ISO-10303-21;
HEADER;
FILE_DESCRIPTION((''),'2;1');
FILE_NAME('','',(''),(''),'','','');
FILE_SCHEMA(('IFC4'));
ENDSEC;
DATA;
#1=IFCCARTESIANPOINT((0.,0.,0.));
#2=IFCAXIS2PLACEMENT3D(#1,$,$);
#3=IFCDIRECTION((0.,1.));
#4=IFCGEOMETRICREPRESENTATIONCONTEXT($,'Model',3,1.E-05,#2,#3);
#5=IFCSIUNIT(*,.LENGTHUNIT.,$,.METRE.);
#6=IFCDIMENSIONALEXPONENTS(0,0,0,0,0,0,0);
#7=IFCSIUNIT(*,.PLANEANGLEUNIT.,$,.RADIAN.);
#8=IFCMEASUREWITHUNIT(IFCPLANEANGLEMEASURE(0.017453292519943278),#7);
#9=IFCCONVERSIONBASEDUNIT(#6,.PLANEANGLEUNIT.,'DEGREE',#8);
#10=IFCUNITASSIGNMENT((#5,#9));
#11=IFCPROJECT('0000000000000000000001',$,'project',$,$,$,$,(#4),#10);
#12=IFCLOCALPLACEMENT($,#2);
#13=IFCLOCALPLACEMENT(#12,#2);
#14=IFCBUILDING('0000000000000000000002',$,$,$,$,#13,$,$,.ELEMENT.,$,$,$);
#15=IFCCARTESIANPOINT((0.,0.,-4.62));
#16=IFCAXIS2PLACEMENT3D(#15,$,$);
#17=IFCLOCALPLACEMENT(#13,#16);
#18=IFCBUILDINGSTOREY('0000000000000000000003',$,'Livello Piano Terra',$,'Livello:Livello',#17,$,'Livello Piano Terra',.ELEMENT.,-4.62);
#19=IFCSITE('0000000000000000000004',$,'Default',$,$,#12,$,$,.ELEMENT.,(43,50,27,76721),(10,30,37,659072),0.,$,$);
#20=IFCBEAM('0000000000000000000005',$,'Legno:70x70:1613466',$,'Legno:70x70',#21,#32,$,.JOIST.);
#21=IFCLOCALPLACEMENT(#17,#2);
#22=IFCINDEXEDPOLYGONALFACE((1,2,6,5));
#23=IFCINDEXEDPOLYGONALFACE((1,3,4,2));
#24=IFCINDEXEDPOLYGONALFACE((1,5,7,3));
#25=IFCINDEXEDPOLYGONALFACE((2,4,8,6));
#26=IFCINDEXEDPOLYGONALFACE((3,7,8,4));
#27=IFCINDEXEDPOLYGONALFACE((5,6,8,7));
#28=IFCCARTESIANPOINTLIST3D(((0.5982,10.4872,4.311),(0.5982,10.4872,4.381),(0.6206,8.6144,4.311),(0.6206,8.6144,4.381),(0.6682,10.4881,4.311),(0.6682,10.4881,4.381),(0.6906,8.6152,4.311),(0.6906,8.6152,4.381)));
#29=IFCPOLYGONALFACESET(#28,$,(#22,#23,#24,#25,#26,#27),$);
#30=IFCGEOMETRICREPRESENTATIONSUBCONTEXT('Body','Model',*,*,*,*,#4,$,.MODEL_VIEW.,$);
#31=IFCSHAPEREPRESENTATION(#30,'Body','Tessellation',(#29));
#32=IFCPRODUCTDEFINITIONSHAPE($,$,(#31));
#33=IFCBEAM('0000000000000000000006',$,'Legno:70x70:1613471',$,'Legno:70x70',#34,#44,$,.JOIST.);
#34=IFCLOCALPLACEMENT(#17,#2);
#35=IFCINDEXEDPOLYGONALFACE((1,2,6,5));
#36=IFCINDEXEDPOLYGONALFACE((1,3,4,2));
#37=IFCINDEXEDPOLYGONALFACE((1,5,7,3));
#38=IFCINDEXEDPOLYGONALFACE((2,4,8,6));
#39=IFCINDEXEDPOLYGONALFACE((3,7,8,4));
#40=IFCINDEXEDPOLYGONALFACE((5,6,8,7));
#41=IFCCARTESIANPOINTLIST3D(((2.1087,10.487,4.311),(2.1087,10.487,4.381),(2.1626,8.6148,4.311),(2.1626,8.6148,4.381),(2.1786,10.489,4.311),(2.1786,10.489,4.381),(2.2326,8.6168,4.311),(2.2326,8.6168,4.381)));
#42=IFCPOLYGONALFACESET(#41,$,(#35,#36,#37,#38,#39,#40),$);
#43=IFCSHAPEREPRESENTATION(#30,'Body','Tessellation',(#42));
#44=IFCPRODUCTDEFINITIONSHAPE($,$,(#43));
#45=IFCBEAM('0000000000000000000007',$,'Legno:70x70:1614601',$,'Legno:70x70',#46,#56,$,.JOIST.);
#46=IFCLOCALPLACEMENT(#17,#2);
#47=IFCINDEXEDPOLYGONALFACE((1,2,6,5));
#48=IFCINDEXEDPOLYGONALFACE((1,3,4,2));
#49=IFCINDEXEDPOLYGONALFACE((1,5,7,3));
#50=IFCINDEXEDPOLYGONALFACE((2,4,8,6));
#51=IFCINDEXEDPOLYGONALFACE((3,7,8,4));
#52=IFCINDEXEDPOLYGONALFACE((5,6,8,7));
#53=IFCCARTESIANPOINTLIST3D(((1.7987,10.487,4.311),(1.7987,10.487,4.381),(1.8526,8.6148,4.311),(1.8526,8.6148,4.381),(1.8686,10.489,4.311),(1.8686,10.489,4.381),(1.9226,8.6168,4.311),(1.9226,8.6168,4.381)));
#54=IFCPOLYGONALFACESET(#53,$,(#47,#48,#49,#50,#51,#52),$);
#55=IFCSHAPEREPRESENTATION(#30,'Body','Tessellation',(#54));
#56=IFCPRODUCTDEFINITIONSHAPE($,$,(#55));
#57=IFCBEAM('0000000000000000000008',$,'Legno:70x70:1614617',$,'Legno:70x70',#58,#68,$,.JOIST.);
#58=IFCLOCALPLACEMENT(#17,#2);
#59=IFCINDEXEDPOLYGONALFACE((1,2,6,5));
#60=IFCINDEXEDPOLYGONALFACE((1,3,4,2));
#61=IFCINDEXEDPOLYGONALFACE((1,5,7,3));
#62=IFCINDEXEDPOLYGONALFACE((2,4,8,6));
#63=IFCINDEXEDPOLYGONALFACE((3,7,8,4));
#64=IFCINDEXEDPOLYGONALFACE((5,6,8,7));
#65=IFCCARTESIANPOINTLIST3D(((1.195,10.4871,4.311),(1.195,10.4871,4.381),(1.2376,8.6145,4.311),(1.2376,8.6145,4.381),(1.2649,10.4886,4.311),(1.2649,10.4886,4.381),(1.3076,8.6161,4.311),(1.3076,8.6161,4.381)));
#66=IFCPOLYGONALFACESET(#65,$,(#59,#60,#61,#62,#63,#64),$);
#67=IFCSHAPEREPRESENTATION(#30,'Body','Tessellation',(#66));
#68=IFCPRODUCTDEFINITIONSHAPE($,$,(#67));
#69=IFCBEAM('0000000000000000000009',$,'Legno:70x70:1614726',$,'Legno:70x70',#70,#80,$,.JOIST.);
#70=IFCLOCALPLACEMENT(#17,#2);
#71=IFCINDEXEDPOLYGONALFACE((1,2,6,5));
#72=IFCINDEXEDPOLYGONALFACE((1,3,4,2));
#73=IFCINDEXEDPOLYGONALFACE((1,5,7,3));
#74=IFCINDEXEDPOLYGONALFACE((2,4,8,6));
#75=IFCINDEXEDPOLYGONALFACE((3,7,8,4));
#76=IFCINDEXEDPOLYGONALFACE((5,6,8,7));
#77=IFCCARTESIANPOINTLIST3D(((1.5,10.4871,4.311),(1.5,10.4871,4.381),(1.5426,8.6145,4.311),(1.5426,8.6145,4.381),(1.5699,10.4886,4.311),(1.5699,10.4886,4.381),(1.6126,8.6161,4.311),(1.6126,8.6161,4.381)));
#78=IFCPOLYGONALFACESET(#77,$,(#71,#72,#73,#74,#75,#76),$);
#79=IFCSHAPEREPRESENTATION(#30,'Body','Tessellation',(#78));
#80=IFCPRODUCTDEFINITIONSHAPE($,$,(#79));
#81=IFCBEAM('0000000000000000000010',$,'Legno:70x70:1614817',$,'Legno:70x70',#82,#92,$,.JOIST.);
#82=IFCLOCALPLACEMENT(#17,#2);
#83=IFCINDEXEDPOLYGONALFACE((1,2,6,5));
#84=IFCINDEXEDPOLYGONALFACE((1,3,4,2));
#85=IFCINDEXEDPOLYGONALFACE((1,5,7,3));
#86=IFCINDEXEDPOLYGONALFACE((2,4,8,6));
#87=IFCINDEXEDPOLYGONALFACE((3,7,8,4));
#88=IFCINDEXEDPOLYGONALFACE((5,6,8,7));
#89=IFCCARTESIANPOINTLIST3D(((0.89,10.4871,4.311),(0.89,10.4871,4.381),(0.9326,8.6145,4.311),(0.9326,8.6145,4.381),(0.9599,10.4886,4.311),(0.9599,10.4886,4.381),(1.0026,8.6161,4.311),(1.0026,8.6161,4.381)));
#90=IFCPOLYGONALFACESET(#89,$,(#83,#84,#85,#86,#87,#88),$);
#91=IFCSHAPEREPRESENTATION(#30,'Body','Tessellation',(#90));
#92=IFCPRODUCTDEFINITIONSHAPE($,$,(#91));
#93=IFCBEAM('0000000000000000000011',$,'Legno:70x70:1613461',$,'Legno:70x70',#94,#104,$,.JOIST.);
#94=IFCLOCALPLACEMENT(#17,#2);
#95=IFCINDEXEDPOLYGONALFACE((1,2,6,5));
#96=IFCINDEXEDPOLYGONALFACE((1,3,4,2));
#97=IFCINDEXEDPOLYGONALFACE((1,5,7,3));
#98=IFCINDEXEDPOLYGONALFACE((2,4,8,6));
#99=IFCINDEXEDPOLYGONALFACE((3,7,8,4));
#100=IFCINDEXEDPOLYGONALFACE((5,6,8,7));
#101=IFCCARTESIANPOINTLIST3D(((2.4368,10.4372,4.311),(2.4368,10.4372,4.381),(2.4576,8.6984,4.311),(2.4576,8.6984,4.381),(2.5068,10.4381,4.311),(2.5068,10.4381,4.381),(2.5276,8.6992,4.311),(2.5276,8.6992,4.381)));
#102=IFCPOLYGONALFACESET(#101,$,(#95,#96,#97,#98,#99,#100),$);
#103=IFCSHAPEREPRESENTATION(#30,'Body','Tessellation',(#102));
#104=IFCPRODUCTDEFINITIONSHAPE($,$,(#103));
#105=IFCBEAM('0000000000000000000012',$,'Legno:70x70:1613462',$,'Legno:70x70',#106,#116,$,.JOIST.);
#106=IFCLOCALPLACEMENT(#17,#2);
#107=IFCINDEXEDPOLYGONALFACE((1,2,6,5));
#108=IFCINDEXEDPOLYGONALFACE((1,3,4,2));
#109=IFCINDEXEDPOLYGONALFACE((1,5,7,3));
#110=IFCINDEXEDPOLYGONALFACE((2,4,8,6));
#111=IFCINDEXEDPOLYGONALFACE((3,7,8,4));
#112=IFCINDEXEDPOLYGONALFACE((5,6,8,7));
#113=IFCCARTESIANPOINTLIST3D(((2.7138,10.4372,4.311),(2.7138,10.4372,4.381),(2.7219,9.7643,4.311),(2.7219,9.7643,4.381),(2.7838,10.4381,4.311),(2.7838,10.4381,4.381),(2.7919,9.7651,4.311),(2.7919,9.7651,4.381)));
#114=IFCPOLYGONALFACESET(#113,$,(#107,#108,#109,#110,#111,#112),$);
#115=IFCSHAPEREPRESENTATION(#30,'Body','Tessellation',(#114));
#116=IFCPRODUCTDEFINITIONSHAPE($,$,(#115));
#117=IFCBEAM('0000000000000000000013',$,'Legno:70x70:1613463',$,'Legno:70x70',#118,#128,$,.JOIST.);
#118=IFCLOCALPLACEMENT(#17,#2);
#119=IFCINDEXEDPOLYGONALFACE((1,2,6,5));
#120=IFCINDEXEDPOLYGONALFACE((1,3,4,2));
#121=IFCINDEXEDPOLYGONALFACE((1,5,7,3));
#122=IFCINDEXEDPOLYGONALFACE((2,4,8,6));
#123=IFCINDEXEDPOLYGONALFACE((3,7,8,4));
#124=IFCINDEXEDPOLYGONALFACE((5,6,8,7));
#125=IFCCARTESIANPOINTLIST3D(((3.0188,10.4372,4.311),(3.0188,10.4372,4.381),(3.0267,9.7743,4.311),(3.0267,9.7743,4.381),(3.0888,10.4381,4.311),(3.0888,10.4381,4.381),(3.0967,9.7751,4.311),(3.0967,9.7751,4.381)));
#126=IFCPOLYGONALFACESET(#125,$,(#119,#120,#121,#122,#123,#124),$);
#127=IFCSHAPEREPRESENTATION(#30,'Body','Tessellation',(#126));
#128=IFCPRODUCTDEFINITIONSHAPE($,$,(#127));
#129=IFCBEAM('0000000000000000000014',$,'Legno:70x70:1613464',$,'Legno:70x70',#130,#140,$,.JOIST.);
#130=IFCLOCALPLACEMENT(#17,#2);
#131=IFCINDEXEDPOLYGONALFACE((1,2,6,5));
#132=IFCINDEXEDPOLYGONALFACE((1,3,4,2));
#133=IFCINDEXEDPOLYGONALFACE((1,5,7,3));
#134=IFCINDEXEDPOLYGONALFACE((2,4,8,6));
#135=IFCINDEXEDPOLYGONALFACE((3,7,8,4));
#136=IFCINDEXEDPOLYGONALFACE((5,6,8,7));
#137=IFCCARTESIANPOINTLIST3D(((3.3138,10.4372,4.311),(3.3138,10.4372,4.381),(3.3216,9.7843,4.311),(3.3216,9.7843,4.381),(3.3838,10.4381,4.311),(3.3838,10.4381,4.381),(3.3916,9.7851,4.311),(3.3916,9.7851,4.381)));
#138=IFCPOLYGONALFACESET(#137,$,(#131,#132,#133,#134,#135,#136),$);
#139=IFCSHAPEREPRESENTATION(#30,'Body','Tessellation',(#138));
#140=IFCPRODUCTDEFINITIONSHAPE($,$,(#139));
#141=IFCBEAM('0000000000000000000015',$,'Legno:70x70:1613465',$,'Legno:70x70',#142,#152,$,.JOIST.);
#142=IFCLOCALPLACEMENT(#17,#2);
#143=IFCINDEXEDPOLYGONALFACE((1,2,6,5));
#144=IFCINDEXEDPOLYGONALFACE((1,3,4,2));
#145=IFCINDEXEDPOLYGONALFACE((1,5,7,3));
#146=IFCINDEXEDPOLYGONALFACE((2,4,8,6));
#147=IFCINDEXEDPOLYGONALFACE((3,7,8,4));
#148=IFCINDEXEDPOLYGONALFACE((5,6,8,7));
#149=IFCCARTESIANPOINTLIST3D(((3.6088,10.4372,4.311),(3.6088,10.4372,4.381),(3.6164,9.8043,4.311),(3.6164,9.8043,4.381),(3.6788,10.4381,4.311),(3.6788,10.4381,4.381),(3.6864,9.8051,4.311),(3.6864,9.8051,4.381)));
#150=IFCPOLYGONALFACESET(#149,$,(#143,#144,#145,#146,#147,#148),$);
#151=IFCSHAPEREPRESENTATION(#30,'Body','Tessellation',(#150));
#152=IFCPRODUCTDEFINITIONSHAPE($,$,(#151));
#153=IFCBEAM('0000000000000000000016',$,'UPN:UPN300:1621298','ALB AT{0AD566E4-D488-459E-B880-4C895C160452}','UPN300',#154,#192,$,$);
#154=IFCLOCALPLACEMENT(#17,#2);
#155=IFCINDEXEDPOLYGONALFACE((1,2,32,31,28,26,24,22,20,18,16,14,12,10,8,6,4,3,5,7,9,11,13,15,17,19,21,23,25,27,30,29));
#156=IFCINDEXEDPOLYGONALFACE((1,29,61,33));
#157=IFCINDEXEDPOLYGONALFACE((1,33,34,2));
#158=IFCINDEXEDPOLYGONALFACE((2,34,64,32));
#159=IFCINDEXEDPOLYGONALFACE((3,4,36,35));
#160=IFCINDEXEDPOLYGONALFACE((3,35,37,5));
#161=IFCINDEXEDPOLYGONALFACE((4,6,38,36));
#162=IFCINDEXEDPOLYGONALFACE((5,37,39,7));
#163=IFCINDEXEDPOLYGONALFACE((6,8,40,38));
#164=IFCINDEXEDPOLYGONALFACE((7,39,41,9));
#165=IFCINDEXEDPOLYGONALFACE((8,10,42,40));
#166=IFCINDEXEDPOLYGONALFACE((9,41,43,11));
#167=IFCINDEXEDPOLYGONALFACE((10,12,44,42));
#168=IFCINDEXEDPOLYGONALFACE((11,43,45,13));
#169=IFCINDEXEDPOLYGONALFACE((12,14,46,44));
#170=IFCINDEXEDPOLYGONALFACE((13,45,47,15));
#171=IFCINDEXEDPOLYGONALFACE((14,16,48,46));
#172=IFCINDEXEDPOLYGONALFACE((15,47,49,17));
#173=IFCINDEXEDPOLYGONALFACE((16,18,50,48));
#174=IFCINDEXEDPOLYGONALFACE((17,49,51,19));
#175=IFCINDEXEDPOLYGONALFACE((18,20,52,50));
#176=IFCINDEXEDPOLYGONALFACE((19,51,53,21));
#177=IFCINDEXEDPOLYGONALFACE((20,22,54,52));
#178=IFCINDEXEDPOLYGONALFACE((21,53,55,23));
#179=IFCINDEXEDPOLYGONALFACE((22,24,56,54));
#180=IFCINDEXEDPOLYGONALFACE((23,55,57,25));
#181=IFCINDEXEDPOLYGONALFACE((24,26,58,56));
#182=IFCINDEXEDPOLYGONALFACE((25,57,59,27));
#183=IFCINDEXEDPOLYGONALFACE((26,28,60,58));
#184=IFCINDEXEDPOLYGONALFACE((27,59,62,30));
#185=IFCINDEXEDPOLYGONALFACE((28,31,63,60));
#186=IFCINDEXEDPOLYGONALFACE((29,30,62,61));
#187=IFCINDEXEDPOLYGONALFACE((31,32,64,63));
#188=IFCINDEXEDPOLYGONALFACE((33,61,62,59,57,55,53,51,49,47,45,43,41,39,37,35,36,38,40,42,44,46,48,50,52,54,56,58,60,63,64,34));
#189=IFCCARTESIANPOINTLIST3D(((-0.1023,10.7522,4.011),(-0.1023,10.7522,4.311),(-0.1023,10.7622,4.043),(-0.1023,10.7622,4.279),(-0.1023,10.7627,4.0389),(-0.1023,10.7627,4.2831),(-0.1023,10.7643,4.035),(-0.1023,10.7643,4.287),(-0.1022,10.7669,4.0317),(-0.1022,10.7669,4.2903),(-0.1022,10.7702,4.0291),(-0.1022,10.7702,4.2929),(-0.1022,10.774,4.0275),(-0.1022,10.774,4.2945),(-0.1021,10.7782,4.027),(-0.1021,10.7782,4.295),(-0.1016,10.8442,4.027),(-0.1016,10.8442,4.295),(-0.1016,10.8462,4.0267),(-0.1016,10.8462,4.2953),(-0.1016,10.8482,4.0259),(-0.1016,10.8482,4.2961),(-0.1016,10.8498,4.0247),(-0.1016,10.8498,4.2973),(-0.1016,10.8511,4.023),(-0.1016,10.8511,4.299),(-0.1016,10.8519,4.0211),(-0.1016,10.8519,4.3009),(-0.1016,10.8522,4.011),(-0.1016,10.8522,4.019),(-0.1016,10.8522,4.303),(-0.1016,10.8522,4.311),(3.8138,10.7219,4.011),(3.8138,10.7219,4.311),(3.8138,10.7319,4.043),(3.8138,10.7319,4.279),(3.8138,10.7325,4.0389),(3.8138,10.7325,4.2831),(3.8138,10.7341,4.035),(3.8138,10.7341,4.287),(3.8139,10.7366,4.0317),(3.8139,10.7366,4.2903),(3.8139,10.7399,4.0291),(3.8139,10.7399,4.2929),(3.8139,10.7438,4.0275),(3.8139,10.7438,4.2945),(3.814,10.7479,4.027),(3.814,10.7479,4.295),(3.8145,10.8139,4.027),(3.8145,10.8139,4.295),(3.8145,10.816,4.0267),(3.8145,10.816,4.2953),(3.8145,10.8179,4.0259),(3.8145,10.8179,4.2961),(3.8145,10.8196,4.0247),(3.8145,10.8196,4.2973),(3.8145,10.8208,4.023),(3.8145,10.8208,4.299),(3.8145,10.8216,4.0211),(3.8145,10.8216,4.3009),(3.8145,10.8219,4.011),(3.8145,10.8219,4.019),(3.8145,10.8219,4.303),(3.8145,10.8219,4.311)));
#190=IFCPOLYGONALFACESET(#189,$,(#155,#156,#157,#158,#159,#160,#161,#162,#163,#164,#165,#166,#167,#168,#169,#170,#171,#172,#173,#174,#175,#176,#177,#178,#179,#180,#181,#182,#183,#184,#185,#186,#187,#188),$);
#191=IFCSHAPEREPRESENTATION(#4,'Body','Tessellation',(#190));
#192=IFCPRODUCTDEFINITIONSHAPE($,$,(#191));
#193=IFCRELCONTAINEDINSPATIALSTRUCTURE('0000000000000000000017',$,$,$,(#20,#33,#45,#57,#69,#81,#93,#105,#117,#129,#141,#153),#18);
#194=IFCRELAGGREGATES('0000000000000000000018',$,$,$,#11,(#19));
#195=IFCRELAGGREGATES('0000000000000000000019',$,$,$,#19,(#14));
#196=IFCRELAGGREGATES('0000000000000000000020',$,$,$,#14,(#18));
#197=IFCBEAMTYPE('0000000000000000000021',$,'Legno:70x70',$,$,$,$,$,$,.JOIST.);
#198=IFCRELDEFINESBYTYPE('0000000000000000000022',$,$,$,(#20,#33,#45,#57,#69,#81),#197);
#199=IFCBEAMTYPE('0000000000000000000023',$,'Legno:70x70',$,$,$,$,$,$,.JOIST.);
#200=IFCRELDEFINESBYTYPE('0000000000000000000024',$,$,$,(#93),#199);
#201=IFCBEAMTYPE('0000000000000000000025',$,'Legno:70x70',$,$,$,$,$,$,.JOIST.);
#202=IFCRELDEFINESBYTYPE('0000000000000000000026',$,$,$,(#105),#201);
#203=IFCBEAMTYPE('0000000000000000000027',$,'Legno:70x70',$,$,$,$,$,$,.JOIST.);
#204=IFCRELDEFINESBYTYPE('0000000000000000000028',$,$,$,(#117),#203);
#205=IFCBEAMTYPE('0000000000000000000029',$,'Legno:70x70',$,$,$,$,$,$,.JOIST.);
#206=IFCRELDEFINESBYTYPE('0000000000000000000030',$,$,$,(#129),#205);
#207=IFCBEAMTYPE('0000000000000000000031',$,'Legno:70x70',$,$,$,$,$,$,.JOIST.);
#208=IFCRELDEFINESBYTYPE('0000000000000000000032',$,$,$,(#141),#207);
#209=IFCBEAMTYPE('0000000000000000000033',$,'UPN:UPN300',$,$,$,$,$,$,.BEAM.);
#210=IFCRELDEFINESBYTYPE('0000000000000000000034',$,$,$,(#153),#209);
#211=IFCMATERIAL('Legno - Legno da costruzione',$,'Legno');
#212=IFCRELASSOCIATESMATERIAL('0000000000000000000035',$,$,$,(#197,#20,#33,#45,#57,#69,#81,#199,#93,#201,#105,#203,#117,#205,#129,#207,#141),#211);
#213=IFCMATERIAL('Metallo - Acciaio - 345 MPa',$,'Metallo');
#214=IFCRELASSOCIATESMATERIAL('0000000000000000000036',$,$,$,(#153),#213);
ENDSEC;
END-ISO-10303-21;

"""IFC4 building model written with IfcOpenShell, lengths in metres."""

from ifc_helpers import new_model, entity, si_unit, converted_unit, direction, frame, frame_2d, origin, place, context, subcontext, project, spatial, indexed_curve, u_section, outline, extrude, source, transform, mapped, material, type_object, type_shapes, element, save


model = new_model("IFC4")

# Units and contexts
model_context = context("Model", 3, precision=1e-05, world=origin(), true_north=direction((0.0, 1.0)))
body_context = subcontext(model_context, "Body", "Model", "MODEL_VIEW")
ifc_project = project(units=[si_unit("LENGTHUNIT", "METRE"), converted_unit("PLANEANGLEUNIT", "DEGREE", entity("IfcPlaneAngleMeasure", 0.017453292519943278), si_unit("PLANEANGLEUNIT", "RADIAN"), dimensions=[0, 0, 0, 0, 0, 0, 0])], contexts=[model_context])

# Site, building, storey
site_placement = place(None, origin())
site = spatial("IfcSite", under=ifc_project, at=site_placement, Name="Default", CompositionType="ELEMENT", RefLatitude=(43, 50, 27, 76721), RefLongitude=(10, 30, 37, 659072), RefElevation=0.0)
building_placement = place(site_placement, origin())
building = spatial("IfcBuilding", under=site, at=building_placement, CompositionType="ELEMENT")
storey_placement = place(building_placement, frame((0.0, 0.0, -4.62)))
storey = spatial("IfcBuildingStorey", under=building, at=storey_placement, Name="Livello Piano Terra", ObjectType="Livello:Livello", LongName="Livello Piano Terra", CompositionType="ELEMENT", Elevation=-4.62)

# Beams
ifc_material_1 = material(Name="Legno - Legno da costruzione", Category="Legno")
beam_type_1 = type_object("IfcBeamType", Name="Legno:70x70", PredefinedType="JOIST", material=ifc_material_1)
shared_shape_1 = source(origin(), body_context, "Body", "SweptSolid", [
    extrude(outline(indexed_curve([(-0.9365, -0.035), (0.9365, -0.035), (0.9365, 0.035), (-0.9365, 0.035), (-0.9365, -0.035)], self_intersect=False)), frame((0.05, 0.0, -0.035), z_axis=(0.0, 0.0, 1.0), x_axis=(-1.0, 0.0, 0.0)), (0.0, 0.0, 1.0), 0.07),
])
type_shapes(beam_type_1, [shared_shape_1])
for number, where, z_axis, x_axis, name in (
    (1, (0.6438, 9.6012, 4.346), (0.0, 0.0, 1.0), (0.011914, -0.999929, 0.0), "Legno:70x70:1613466"),
    (2, (2.1692, 9.6019, 4.346), (0.0, 0.0, 1.0), (0.028801, -0.999585, 0.0), "Legno:70x70:1613471"),
    (3, (1.8592, 9.6019, 4.346), (0.0, 0.0, 1.0), (0.028801, -0.999585, 0.0), "Legno:70x70:1614601"),
    (4, (1.2501, 9.6016, 4.346), (0.0, 0.0, 1.0), (0.02276, -0.999741, 0.0), "Legno:70x70:1614617"),
    (5, (1.5551, 9.6016, 4.346), (0.0, 0.0, 1.0), (0.02276, -0.999741, 0.0), "Legno:70x70:1614726"),
    (6, (0.9451, 9.6016, 4.346), (0.0, 0.0, 1.0), (0.02276, -0.999741, 0.0), "Legno:70x70:1614817"),
):
    element("IfcBeam", number, at=place(storey_placement, frame(where, z_axis=z_axis, x_axis=x_axis)), inside=storey, type_object=beam_type_1, material=ifc_material_1, Name=name, ObjectType="Legno:70x70", PredefinedType="JOIST", context=body_context, shape_type="MappedRepresentation", body=[
        mapped(shared_shape_1, transform((0.0, 0.0, 0.0), scale=1.0)),
    ])
beam_type_2 = type_object("IfcBeamType", Name="Legno:70x70", PredefinedType="JOIST", material=ifc_material_1)
shared_shape_2 = source(origin(), body_context, "Body", "SweptSolid", [
    extrude(outline(indexed_curve([(-0.8695, -0.035), (0.8695, -0.035), (0.8695, 0.035), (-0.8695, 0.035), (-0.8695, -0.035)], self_intersect=False)), frame((0.033, 0.0, -0.035), z_axis=(0.0, 0.0, 1.0), x_axis=(-1.0, 0.0, 0.0)), (0.0, 0.0, 1.0), 0.07),
])
type_shapes(beam_type_2, [shared_shape_2])
beam_1_placement = place(storey_placement, frame((2.4818, 9.6012, 4.346), z_axis=(0.0, 0.0, 1.0), x_axis=(0.011914, -0.999929, 0.0)))
element("IfcBeam", 7, at=beam_1_placement, inside=storey, type_object=beam_type_2, material=ifc_material_1, Name="Legno:70x70:1613461", ObjectType="Legno:70x70", PredefinedType="JOIST", context=body_context, shape_type="MappedRepresentation", body=[
    mapped(shared_shape_2, transform((0.0, 0.0, 0.0), scale=1.0)),
])
beam_type_3 = type_object("IfcBeamType", Name="Legno:70x70", PredefinedType="JOIST", material=ifc_material_1)
shared_shape_3 = source(origin(), body_context, "Body", "SweptSolid", [
    extrude(outline(indexed_curve([(-0.3365, -0.035), (0.3365, -0.035), (0.3365, 0.035), (-0.3365, 0.035), (-0.3365, -0.035)], self_intersect=False)), frame((-0.5, 0.0, -0.035), z_axis=(0.0, 0.0, 1.0), x_axis=(-1.0, 0.0, 0.0)), (0.0, 0.0, 1.0), 0.07),
])
type_shapes(beam_type_3, [shared_shape_3])
beam_2_placement = place(storey_placement, frame((2.7588, 9.6012, 4.346), z_axis=(0.0, 0.0, 1.0), x_axis=(0.011914, -0.999929, 0.0)))
element("IfcBeam", 8, at=beam_2_placement, inside=storey, type_object=beam_type_3, material=ifc_material_1, Name="Legno:70x70:1613462", ObjectType="Legno:70x70", PredefinedType="JOIST", context=body_context, shape_type="MappedRepresentation", body=[
    mapped(shared_shape_3, transform((0.0, 0.0, 0.0), scale=1.0)),
])
beam_type_4 = type_object("IfcBeamType", Name="Legno:70x70", PredefinedType="JOIST", material=ifc_material_1)
shared_shape_4 = source(origin(), body_context, "Body", "SweptSolid", [
    extrude(outline(indexed_curve([(-0.3315, -0.035), (0.3315, -0.035), (0.3315, 0.035), (-0.3315, 0.035), (-0.3315, -0.035)], self_intersect=False)), frame((-0.505, 0.0, -0.035), z_axis=(0.0, 0.0, 1.0), x_axis=(-1.0, 0.0, 0.0)), (0.0, 0.0, 1.0), 0.07),
])
type_shapes(beam_type_4, [shared_shape_4])
beam_3_placement = place(storey_placement, frame((3.0638, 9.6012, 4.346), z_axis=(0.0, 0.0, 1.0), x_axis=(0.011914, -0.999929, 0.0)))
element("IfcBeam", 9, at=beam_3_placement, inside=storey, type_object=beam_type_4, material=ifc_material_1, Name="Legno:70x70:1613463", ObjectType="Legno:70x70", PredefinedType="JOIST", context=body_context, shape_type="MappedRepresentation", body=[
    mapped(shared_shape_4, transform((0.0, 0.0, 0.0), scale=1.0)),
])
beam_type_5 = type_object("IfcBeamType", Name="Legno:70x70", PredefinedType="JOIST", material=ifc_material_1)
shared_shape_5 = source(origin(), body_context, "Body", "SweptSolid", [
    extrude(outline(indexed_curve([(-0.3265, -0.035), (0.3265, -0.035), (0.3265, 0.035), (-0.3265, 0.035), (-0.3265, -0.035)], self_intersect=False)), frame((-0.51, 0.0, -0.035), z_axis=(0.0, 0.0, 1.0), x_axis=(-1.0, 0.0, 0.0)), (0.0, 0.0, 1.0), 0.07),
])
type_shapes(beam_type_5, [shared_shape_5])
beam_4_placement = place(storey_placement, frame((3.3588, 9.6012, 4.346), z_axis=(0.0, 0.0, 1.0), x_axis=(0.011914, -0.999929, 0.0)))
element("IfcBeam", 10, at=beam_4_placement, inside=storey, type_object=beam_type_5, material=ifc_material_1, Name="Legno:70x70:1613464", ObjectType="Legno:70x70", PredefinedType="JOIST", context=body_context, shape_type="MappedRepresentation", body=[
    mapped(shared_shape_5, transform((0.0, 0.0, 0.0), scale=1.0)),
])
beam_type_6 = type_object("IfcBeamType", Name="Legno:70x70", PredefinedType="JOIST", material=ifc_material_1)
shared_shape_6 = source(origin(), body_context, "Body", "SweptSolid", [
    extrude(outline(indexed_curve([(-0.3165, -0.035), (0.3165, -0.035), (0.3165, 0.035), (-0.3165, 0.035), (-0.3165, -0.035)], self_intersect=False)), frame((-0.52, 0.0, -0.035), z_axis=(0.0, 0.0, 1.0), x_axis=(-1.0, 0.0, 0.0)), (0.0, 0.0, 1.0), 0.07),
])
type_shapes(beam_type_6, [shared_shape_6])
beam_5_placement = place(storey_placement, frame((3.6538, 9.6012, 4.346), z_axis=(0.0, 0.0, 1.0), x_axis=(0.011914, -0.999929, 0.0)))
element("IfcBeam", 11, at=beam_5_placement, inside=storey, type_object=beam_type_6, material=ifc_material_1, Name="Legno:70x70:1613465", ObjectType="Legno:70x70", PredefinedType="JOIST", context=body_context, shape_type="MappedRepresentation", body=[
    mapped(shared_shape_6, transform((0.0, 0.0, 0.0), scale=1.0)),
])
ifc_material_2 = material(Name="Metallo - Acciaio - 345 MPa", Category="Metallo")
beam_type_7 = type_object("IfcBeamType", Name="UPN:UPN300", PredefinedType="BEAM")
beam_6_placement = place(storey_placement, frame((3.814, 10.7489, 4.161), z_axis=(0.99997, -0.007726, 0.0), x_axis=(0.007726, 0.99997, 0.0)))
element("IfcBeam", 12, at=beam_6_placement, inside=storey, type_object=beam_type_7, material=ifc_material_2, Name="UPN:UPN300:1621298", Description="ALB AT{0AD566E4-D488-459E-B880-4C895C160452}", ObjectType="UPN300", context=model_context, shape_type="SweptSolid", body=[
    extrude(u_section(Depth=0.3, FlangeWidth=0.1, WebThickness=0.01, FlangeThickness=0.016, FilletRadius=0.016, EdgeRadius=0.008, FlangeSlope=0.00457, at=frame_2d((0.023, 0.0))), origin(), (0.0, 0.0, -1.0), 3.9162),
])

save(model, "model.ifc")
